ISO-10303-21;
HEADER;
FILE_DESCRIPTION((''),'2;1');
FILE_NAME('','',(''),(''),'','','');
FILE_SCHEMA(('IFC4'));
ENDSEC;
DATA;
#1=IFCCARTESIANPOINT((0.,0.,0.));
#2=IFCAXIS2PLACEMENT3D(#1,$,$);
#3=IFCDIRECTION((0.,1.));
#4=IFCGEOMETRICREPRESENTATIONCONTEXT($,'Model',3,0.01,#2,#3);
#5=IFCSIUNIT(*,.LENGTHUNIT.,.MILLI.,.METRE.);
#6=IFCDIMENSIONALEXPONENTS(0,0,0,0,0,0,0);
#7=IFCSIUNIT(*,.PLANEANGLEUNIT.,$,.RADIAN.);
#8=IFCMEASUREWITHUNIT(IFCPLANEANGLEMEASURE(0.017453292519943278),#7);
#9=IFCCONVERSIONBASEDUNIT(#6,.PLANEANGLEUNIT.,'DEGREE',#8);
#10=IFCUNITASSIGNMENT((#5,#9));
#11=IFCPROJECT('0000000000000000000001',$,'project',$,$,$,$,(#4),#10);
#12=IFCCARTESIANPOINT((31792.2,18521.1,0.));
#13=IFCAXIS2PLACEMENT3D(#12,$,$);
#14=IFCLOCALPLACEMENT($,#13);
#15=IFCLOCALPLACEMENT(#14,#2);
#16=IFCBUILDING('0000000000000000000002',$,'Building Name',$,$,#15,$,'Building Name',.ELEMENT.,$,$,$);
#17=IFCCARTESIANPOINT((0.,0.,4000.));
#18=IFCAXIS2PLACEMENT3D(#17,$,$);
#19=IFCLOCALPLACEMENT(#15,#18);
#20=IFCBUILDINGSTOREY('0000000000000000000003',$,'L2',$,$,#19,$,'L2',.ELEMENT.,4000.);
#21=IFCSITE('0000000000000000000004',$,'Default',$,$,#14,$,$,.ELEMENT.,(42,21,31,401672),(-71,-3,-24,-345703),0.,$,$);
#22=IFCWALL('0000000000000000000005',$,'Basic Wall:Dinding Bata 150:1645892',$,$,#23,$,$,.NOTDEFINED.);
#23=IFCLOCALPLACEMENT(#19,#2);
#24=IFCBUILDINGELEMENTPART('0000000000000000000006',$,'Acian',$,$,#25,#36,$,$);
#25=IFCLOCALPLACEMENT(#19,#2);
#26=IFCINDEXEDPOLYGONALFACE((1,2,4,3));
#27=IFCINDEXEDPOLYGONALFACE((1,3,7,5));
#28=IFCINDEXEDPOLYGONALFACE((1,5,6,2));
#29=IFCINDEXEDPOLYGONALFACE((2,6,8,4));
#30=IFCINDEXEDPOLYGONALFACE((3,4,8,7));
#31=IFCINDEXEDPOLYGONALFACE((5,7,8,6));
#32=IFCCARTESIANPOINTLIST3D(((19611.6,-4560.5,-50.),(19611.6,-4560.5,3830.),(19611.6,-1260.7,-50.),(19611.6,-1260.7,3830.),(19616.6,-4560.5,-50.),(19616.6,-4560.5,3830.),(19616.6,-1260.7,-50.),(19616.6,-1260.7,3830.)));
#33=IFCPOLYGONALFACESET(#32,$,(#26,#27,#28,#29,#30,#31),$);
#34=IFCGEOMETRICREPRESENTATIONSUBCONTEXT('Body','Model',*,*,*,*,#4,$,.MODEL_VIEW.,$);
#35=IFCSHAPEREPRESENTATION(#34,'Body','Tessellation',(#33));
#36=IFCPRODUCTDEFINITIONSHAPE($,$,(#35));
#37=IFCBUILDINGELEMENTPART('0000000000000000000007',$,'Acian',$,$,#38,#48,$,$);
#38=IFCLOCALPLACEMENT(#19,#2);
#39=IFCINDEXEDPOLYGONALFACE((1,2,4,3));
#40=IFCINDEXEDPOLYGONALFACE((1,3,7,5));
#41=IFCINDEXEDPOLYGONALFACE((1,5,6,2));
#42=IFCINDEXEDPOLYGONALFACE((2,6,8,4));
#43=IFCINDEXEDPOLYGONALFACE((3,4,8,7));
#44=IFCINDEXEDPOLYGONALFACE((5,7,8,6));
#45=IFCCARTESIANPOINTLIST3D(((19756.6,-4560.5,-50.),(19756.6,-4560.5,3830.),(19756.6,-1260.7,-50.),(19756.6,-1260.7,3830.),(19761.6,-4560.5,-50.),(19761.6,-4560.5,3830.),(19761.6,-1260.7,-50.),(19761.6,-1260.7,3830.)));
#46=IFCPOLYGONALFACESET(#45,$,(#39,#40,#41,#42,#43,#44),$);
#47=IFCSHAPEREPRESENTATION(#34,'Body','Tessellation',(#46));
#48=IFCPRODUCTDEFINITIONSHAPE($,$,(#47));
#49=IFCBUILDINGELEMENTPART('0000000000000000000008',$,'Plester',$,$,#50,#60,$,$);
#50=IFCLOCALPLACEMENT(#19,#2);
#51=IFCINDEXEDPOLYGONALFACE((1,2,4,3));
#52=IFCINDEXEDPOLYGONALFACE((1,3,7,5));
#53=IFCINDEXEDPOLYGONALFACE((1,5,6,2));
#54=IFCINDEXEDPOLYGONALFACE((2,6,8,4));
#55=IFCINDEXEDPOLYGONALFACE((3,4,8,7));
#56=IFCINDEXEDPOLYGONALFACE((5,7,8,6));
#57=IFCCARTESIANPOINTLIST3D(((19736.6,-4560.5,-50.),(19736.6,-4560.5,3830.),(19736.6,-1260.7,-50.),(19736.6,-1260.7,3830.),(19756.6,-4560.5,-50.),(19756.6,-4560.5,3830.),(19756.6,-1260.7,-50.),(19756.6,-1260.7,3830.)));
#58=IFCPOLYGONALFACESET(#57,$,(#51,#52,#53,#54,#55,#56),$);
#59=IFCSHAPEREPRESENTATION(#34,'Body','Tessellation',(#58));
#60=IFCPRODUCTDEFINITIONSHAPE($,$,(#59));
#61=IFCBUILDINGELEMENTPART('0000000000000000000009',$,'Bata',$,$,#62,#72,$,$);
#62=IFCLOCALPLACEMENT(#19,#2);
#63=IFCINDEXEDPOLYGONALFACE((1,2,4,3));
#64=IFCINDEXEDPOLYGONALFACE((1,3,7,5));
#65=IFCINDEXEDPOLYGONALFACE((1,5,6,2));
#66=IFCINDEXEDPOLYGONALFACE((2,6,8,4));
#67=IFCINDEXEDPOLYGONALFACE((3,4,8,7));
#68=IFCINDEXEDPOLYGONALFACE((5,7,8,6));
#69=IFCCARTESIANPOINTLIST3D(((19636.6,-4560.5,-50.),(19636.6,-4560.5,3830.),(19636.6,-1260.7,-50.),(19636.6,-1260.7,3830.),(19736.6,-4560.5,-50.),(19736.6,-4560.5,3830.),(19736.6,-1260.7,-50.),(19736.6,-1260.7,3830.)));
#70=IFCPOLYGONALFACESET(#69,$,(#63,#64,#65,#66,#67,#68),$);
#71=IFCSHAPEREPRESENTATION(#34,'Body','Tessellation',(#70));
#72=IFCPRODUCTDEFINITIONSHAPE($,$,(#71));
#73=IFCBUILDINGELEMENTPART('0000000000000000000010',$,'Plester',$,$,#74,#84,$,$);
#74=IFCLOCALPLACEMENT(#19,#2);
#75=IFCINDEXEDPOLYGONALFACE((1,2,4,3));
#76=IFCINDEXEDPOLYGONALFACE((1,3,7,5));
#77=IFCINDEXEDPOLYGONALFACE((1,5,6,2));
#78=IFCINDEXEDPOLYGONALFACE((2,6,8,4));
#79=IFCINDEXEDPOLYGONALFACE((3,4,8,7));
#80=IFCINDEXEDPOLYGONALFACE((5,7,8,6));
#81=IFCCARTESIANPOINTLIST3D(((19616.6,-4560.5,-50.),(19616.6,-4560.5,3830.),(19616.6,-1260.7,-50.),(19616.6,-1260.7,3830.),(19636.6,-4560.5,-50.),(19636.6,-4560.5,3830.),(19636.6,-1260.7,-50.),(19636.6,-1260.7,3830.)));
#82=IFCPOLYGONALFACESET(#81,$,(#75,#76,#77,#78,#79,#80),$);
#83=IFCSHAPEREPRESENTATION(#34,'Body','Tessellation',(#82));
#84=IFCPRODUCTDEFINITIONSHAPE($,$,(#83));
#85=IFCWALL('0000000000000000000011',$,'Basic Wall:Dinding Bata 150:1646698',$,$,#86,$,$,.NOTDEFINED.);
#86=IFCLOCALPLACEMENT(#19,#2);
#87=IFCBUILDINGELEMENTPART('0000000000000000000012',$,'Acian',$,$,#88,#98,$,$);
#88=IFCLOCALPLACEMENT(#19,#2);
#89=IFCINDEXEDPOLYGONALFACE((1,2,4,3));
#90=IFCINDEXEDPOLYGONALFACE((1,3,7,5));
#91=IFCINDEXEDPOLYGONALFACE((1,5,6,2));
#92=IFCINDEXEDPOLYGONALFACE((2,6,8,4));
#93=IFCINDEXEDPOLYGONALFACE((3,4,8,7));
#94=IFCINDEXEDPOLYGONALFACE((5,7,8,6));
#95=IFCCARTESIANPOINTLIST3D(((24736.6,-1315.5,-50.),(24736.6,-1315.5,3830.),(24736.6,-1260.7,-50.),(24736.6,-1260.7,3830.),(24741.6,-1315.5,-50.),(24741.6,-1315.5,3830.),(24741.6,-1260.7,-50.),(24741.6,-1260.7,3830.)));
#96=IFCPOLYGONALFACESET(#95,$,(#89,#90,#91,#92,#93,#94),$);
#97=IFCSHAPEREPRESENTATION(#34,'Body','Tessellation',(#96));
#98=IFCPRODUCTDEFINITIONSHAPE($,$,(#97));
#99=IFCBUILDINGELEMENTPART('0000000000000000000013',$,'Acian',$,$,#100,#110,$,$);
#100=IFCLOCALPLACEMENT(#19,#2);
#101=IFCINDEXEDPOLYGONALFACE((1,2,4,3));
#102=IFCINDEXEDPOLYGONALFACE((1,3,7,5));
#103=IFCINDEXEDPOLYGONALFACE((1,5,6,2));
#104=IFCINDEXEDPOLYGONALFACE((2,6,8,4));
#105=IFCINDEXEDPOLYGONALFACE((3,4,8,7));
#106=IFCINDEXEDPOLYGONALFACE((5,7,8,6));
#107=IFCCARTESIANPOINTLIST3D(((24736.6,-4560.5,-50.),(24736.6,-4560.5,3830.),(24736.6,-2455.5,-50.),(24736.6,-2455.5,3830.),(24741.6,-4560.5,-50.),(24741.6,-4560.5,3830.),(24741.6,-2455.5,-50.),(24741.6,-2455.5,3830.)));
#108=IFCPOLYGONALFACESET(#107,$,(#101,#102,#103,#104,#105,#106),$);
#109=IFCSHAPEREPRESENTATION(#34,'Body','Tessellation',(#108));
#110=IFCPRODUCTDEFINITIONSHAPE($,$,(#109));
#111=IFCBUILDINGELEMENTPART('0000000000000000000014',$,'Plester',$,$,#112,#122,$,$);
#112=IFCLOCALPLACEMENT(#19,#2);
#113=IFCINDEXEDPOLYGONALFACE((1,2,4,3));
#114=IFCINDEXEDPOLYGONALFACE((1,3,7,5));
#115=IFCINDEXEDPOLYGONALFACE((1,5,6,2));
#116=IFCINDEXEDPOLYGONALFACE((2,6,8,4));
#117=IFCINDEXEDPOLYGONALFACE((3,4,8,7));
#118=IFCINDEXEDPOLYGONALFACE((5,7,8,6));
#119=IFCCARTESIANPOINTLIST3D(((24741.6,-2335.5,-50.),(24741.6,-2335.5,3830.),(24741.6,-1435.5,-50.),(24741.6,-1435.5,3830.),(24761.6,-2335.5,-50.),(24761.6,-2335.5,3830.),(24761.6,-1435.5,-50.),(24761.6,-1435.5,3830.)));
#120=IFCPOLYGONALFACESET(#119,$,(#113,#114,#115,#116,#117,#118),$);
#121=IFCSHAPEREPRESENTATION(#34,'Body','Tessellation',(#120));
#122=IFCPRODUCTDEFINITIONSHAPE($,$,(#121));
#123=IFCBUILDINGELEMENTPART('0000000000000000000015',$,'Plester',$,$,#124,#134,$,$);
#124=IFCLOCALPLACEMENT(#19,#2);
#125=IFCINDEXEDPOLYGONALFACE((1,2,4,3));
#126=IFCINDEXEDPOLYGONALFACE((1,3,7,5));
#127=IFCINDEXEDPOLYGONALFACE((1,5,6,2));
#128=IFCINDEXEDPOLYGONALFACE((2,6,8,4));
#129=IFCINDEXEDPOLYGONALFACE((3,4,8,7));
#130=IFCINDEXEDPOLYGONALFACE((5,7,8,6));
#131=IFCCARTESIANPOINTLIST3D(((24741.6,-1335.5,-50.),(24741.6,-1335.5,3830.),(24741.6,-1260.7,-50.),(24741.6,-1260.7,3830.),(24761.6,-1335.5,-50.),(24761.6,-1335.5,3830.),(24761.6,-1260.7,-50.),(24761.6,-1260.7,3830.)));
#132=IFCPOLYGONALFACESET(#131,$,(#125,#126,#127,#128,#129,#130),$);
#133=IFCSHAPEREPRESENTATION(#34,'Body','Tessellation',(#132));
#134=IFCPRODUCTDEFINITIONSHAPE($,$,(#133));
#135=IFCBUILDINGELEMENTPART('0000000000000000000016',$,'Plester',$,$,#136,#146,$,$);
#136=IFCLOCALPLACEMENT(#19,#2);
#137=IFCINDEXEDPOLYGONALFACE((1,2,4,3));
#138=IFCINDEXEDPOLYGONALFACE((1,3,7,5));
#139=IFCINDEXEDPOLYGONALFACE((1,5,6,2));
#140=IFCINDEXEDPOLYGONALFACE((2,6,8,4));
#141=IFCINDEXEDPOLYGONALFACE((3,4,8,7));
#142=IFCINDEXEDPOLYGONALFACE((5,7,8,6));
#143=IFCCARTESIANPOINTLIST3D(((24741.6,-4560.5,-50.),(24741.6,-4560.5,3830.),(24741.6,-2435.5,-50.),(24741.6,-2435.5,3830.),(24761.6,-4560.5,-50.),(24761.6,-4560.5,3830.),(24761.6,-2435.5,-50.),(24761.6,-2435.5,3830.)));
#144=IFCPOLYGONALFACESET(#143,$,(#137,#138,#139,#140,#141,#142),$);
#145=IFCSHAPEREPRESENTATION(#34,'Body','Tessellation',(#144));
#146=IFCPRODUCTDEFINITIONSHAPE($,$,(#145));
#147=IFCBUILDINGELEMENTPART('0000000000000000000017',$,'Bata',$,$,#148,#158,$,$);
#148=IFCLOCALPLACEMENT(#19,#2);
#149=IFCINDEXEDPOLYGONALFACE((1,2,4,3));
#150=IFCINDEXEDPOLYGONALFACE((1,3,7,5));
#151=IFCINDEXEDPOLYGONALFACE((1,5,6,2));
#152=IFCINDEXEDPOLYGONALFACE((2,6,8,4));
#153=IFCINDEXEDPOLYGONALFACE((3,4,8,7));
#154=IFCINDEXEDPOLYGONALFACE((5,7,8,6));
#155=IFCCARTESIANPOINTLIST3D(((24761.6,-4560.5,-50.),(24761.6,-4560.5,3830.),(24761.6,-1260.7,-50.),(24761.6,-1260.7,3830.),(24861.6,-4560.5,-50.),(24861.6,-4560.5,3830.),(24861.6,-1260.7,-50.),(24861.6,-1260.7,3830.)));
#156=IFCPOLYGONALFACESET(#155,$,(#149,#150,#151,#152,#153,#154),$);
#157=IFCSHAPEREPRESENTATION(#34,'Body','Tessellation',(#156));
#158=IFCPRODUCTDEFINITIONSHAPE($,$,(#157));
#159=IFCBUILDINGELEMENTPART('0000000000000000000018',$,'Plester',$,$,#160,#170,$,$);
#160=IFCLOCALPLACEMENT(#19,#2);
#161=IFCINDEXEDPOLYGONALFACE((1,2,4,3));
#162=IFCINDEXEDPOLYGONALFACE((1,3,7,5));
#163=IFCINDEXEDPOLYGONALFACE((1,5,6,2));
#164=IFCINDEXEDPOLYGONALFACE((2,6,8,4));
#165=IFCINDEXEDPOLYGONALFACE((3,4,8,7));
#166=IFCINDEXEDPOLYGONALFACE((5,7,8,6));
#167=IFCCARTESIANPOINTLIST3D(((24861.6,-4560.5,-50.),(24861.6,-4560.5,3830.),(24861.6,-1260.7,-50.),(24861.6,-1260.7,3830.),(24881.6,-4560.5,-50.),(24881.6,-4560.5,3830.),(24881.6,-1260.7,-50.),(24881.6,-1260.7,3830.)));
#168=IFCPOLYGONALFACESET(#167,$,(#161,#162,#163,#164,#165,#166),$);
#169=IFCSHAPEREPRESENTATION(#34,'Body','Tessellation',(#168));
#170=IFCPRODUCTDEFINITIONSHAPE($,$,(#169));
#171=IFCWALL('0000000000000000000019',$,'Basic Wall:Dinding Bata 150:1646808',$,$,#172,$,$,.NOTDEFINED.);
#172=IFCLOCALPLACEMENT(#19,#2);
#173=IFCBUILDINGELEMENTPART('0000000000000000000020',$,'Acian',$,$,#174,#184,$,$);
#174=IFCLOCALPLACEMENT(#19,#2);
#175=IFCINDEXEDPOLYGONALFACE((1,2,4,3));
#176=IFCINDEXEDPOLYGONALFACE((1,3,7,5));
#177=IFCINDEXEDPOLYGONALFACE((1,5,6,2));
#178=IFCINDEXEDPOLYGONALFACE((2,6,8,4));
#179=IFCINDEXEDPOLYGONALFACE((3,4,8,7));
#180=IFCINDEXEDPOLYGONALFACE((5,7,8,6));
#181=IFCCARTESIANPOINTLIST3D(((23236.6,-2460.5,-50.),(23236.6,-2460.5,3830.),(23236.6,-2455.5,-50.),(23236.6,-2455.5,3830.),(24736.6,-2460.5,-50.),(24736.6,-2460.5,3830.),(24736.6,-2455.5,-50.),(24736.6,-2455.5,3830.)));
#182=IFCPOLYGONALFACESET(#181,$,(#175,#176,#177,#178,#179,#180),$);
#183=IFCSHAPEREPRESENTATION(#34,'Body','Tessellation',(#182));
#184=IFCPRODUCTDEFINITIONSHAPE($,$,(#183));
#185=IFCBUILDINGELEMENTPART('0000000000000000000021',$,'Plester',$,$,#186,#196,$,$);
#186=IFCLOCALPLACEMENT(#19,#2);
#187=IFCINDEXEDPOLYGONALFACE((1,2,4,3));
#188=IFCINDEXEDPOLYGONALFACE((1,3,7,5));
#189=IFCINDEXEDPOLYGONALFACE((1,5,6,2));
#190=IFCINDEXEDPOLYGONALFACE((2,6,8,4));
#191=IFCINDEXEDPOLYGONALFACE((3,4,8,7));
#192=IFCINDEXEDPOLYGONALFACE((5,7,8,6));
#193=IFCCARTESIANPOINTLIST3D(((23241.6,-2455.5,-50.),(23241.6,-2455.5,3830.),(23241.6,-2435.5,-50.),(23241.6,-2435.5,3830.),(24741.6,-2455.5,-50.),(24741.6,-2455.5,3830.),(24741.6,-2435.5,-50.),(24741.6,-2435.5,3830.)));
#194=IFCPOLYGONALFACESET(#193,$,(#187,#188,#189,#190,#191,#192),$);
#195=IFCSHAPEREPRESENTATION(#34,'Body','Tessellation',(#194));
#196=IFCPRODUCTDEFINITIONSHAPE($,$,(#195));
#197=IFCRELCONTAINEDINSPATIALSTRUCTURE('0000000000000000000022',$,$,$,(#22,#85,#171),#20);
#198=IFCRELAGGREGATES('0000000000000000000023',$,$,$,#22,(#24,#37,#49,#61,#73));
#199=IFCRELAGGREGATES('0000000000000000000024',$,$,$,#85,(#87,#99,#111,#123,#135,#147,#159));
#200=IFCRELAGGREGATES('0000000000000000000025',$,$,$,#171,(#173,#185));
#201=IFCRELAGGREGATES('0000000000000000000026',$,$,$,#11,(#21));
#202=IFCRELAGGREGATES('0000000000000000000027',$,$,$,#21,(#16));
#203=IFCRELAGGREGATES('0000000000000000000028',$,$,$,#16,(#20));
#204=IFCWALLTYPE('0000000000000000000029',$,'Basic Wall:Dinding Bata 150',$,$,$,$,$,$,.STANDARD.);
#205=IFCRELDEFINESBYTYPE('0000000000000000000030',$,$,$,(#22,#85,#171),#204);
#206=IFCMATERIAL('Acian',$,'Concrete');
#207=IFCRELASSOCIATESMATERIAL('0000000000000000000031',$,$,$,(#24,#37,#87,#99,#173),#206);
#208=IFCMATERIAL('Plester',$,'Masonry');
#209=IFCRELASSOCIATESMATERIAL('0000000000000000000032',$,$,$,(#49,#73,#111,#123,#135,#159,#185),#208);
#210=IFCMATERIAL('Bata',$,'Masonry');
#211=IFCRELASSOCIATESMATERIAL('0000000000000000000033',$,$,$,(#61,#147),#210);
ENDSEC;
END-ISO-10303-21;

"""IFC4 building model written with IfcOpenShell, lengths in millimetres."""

from ifc_helpers import new_model, entity, si_unit, converted_unit, direction, frame, origin, place, context, subcontext, project, spatial, indexed_curve, outline, extrude, material, type_object, element, aggregate, save


model = new_model("IFC4")

# Units and contexts
model_context = context("Model", 3, precision=0.01, world=origin(), true_north=direction((0.0, 1.0)))
body_context = subcontext(model_context, "Body", "Model", "MODEL_VIEW")
ifc_project = project(units=[si_unit("LENGTHUNIT", "METRE", prefix="MILLI"), converted_unit("PLANEANGLEUNIT", "DEGREE", entity("IfcPlaneAngleMeasure", 0.017453292519943278), si_unit("PLANEANGLEUNIT", "RADIAN"), dimensions=[0, 0, 0, 0, 0, 0, 0])], contexts=[model_context])

# Site, building, storey
site_placement = place(None, frame((31792.2, 18521.1, 0.0)))
site = spatial("IfcSite", under=ifc_project, at=site_placement, Name="Default", CompositionType="ELEMENT", RefLatitude=(42, 21, 31, 401672), RefLongitude=(-71, -3, -24, -345703), RefElevation=0.0)
building_placement = place(site_placement, origin())
building = spatial("IfcBuilding", under=site, at=building_placement, Name="Building Name", LongName="Building Name", CompositionType="ELEMENT")
storey_placement = place(building_placement, frame((0.0, 0.0, 4000.0)))
storey = spatial("IfcBuildingStorey", under=building, at=storey_placement, Name="L2", LongName="L2", CompositionType="ELEMENT", Elevation=4000.0)

# Walls, building element parts
wall_type = type_object("IfcWallType", Name="Basic Wall:Dinding Bata 150", PredefinedType="STANDARD")
wall_1_placement = place(storey_placement, frame((19686.6, -1260.7, -50.0), z_axis=(0.0, 0.0, 1.0), x_axis=(0.0, -1.0, 0.0)))
wall_1 = element("IfcWall", 1, at=wall_1_placement, inside=storey, type_object=wall_type, Name="Basic Wall:Dinding Bata 150:1645892", PredefinedType="NOTDEFINED")
ifc_material_1 = material(Name="Acian", Category="Concrete")
building_element_part_1_placement = place(wall_1_placement, origin())
building_element_part_1 = element("IfcBuildingElementPart", 2, at=building_element_part_1_placement, material=ifc_material_1, Name="Acian", context=body_context, shape_type="SweptSolid", body=[
    extrude(outline(indexed_curve([(-1649.9, -2.5), (1649.9, -2.5), (1649.9, 2.5), (-1649.9, 2.5), (-1649.9, -2.5)], self_intersect=False)), frame((1649.9, -72.5, 0.0)), (0.0, 0.0, 1.0), 3880.0),
])
building_element_part_2_placement = place(wall_1_placement, origin())
building_element_part_2 = element("IfcBuildingElementPart", 3, at=building_element_part_2_placement, material=ifc_material_1, Name="Acian", context=body_context, shape_type="SweptSolid", body=[
    extrude(outline(indexed_curve([(-1649.9, -2.5), (1649.9, -2.5), (1649.9, 2.5), (-1649.9, 2.5), (-1649.9, -2.5)], self_intersect=False)), frame((1649.9, 72.5, 0.0)), (0.0, 0.0, 1.0), 3880.0),
])
ifc_material_2 = material(Name="Plester", Category="Masonry")
building_element_part_3_placement = place(wall_1_placement, origin())
building_element_part_3 = element("IfcBuildingElementPart", 4, at=building_element_part_3_placement, material=ifc_material_2, Name="Plester", context=body_context, shape_type="SweptSolid", body=[
    extrude(outline(indexed_curve([(-1649.9, -10.0), (1649.9, -10.0), (1649.9, 10.0), (-1649.9, 10.0), (-1649.9, -10.0)], self_intersect=False)), frame((1649.9, 60.0, 0.0)), (0.0, 0.0, 1.0), 3880.0),
])
ifc_material_3 = material(Name="Bata", Category="Masonry")
building_element_part_4_placement = place(wall_1_placement, origin())
building_element_part_4 = element("IfcBuildingElementPart", 5, at=building_element_part_4_placement, material=ifc_material_3, Name="Bata", context=body_context, shape_type="SweptSolid", body=[
    extrude(outline(indexed_curve([(-1649.9, -50.0), (1649.9, -50.0), (1649.9, 50.0), (-1649.9, 50.0), (-1649.9, -50.0)], self_intersect=False)), frame((1649.9, 0.0, 0.0)), (0.0, 0.0, 1.0), 3880.0),
])
building_element_part_5_placement = place(wall_1_placement, origin())
building_element_part_5 = element("IfcBuildingElementPart", 6, at=building_element_part_5_placement, material=ifc_material_2, Name="Plester", context=body_context, shape_type="SweptSolid", body=[
    extrude(outline(indexed_curve([(-1649.9, -10.0), (1649.9, -10.0), (1649.9, 10.0), (-1649.9, 10.0), (-1649.9, -10.0)], self_intersect=False)), frame((1649.9, -60.0, 0.0)), (0.0, 0.0, 1.0), 3880.0),
])
aggregate(wall_1, [building_element_part_1, building_element_part_2, building_element_part_3, building_element_part_4, building_element_part_5])
wall_2_placement = place(storey_placement, frame((24811.6, -4560.5, -50.0), z_axis=(0.0, 0.0, 1.0), x_axis=(0.0, 1.0, 0.0)))
wall_2 = element("IfcWall", 7, at=wall_2_placement, inside=storey, type_object=wall_type, Name="Basic Wall:Dinding Bata 150:1646698", PredefinedType="NOTDEFINED")
building_element_part_6_placement = place(wall_2_placement, origin())
building_element_part_6 = element("IfcBuildingElementPart", 8, at=building_element_part_6_placement, material=ifc_material_1, Name="Acian", context=body_context, shape_type="SweptSolid", body=[
    extrude(outline(indexed_curve([(-27.4, -2.5), (27.4, -2.5), (27.4, 2.5), (-27.4, 2.5), (-27.4, -2.5)], self_intersect=False)), frame((3272.4, 72.5, 0.0), z_axis=(0.0, 0.0, 1.0), x_axis=(-1.0, 0.0, 0.0)), (0.0, 0.0, 1.0), 3880.0),
])
building_element_part_7_placement = place(wall_2_placement, origin())
building_element_part_7 = element("IfcBuildingElementPart", 9, at=building_element_part_7_placement, material=ifc_material_1, Name="Acian", context=body_context, shape_type="SweptSolid", body=[
    extrude(outline(indexed_curve([(-1052.5, -2.5), (1052.5, -2.5), (1052.5, 2.5), (-1052.5, 2.5), (-1052.5, -2.5)], self_intersect=False)), frame((1052.5, 72.5, 0.0), z_axis=(0.0, 0.0, 1.0), x_axis=(-1.0, 0.0, 0.0)), (0.0, 0.0, 1.0), 3880.0),
])
building_element_part_8_placement = place(wall_2_placement, origin())
building_element_part_8 = element("IfcBuildingElementPart", 10, at=building_element_part_8_placement, material=ifc_material_2, Name="Plester", context=body_context, shape_type="SweptSolid", body=[
    extrude(outline(indexed_curve([(-450.0, -10.0), (450.0, -10.0), (450.0, 10.0), (-450.0, 10.0), (-450.0, -10.0)], self_intersect=False)), frame((2675.0, 60.0, 0.0), z_axis=(0.0, 0.0, 1.0), x_axis=(-1.0, 0.0, 0.0)), (0.0, 0.0, 1.0), 3880.0),
])
building_element_part_9_placement = place(wall_2_placement, origin())
building_element_part_9 = element("IfcBuildingElementPart", 11, at=building_element_part_9_placement, material=ifc_material_2, Name="Plester", context=body_context, shape_type="SweptSolid", body=[
    extrude(outline(indexed_curve([(-37.4, -10.0), (37.4, -10.0), (37.4, 10.0), (-37.4, 10.0), (-37.4, -10.0)], self_intersect=False)), frame((3262.4, 60.0, 0.0), z_axis=(0.0, 0.0, 1.0), x_axis=(-1.0, 0.0, 0.0)), (0.0, 0.0, 1.0), 3880.0),
])
building_element_part_10_placement = place(wall_2_placement, origin())
building_element_part_10 = element("IfcBuildingElementPart", 12, at=building_element_part_10_placement, material=ifc_material_2, Name="Plester", context=body_context, shape_type="SweptSolid", body=[
    extrude(outline(indexed_curve([(-1062.5, -10.0), (1062.5, -10.0), (1062.5, 10.0), (-1062.5, 10.0), (-1062.5, -10.0)], self_intersect=False)), frame((1062.5, 60.0, 0.0), z_axis=(0.0, 0.0, 1.0), x_axis=(-1.0, 0.0, 0.0)), (0.0, 0.0, 1.0), 3880.0),
])
building_element_part_11_placement = place(wall_2_placement, origin())
building_element_part_11 = element("IfcBuildingElementPart", 13, at=building_element_part_11_placement, material=ifc_material_3, Name="Bata", context=body_context, shape_type="SweptSolid", body=[
    extrude(outline(indexed_curve([(-1649.9, -50.0), (1649.9, -50.0), (1649.9, 50.0), (-1649.9, 50.0), (-1649.9, -50.0)], self_intersect=False)), frame((1649.9, 0.0, 0.0), z_axis=(0.0, 0.0, 1.0), x_axis=(-1.0, 0.0, 0.0)), (0.0, 0.0, 1.0), 3880.0),
])
building_element_part_12_placement = place(wall_2_placement, origin())
building_element_part_12 = element("IfcBuildingElementPart", 14, at=building_element_part_12_placement, material=ifc_material_2, Name="Plester", context=body_context, shape_type="SweptSolid", body=[
    extrude(outline(indexed_curve([(-1649.9, -10.0), (1649.9, -10.0), (1649.9, 10.0), (-1649.9, 10.0), (-1649.9, -10.0)], self_intersect=False)), frame((1649.9, -60.0, 0.0), z_axis=(0.0, 0.0, 1.0), x_axis=(-1.0, 0.0, 0.0)), (0.0, 0.0, 1.0), 3880.0),
])
aggregate(wall_2, [building_element_part_6, building_element_part_7, building_element_part_8, building_element_part_9, building_element_part_10, building_element_part_11, building_element_part_12])
wall_3_placement = place(storey_placement, frame((24736.6, -2385.5, -50.0), z_axis=(0.0, 0.0, 1.0), x_axis=(-1.0, 0.0, 0.0)))
wall_3 = element("IfcWall", 15, at=wall_3_placement, inside=storey, type_object=wall_type, Name="Basic Wall:Dinding Bata 150:1646808", PredefinedType="NOTDEFINED")
building_element_part_13_placement = place(wall_3_placement, origin())
building_element_part_13 = element("IfcBuildingElementPart", 16, at=building_element_part_13_placement, material=ifc_material_1, Name="Acian", context=body_context, shape_type="SweptSolid", body=[
    extrude(outline(indexed_curve([(-2.5, -750.0), (2.5, -750.0), (2.5, 750.0), (-2.5, 750.0), (-2.5, -750.0)], self_intersect=False)), frame((750.0, 72.5, 0.0), z_axis=(0.0, 0.0, 1.0), x_axis=(0.0, 1.0, 0.0)), (0.0, 0.0, 1.0), 3880.0),
])
building_element_part_14_placement = place(wall_3_placement, origin())
building_element_part_14 = element("IfcBuildingElementPart", 17, at=building_element_part_14_placement, material=ifc_material_2, Name="Plester", context=body_context, shape_type="SweptSolid", body=[
    extrude(outline(indexed_curve([(-10.0, -750.0), (10.0, -750.0), (10.0, 750.0), (-10.0, 750.0), (-10.0, -750.0)], self_intersect=False)), frame((745.0, 60.0, 0.0), z_axis=(0.0, 0.0, 1.0), x_axis=(0.0, 1.0, 0.0)), (0.0, 0.0, 1.0), 3880.0),
])
aggregate(wall_3, [building_element_part_13, building_element_part_14])

save(model, "model.ifc")
